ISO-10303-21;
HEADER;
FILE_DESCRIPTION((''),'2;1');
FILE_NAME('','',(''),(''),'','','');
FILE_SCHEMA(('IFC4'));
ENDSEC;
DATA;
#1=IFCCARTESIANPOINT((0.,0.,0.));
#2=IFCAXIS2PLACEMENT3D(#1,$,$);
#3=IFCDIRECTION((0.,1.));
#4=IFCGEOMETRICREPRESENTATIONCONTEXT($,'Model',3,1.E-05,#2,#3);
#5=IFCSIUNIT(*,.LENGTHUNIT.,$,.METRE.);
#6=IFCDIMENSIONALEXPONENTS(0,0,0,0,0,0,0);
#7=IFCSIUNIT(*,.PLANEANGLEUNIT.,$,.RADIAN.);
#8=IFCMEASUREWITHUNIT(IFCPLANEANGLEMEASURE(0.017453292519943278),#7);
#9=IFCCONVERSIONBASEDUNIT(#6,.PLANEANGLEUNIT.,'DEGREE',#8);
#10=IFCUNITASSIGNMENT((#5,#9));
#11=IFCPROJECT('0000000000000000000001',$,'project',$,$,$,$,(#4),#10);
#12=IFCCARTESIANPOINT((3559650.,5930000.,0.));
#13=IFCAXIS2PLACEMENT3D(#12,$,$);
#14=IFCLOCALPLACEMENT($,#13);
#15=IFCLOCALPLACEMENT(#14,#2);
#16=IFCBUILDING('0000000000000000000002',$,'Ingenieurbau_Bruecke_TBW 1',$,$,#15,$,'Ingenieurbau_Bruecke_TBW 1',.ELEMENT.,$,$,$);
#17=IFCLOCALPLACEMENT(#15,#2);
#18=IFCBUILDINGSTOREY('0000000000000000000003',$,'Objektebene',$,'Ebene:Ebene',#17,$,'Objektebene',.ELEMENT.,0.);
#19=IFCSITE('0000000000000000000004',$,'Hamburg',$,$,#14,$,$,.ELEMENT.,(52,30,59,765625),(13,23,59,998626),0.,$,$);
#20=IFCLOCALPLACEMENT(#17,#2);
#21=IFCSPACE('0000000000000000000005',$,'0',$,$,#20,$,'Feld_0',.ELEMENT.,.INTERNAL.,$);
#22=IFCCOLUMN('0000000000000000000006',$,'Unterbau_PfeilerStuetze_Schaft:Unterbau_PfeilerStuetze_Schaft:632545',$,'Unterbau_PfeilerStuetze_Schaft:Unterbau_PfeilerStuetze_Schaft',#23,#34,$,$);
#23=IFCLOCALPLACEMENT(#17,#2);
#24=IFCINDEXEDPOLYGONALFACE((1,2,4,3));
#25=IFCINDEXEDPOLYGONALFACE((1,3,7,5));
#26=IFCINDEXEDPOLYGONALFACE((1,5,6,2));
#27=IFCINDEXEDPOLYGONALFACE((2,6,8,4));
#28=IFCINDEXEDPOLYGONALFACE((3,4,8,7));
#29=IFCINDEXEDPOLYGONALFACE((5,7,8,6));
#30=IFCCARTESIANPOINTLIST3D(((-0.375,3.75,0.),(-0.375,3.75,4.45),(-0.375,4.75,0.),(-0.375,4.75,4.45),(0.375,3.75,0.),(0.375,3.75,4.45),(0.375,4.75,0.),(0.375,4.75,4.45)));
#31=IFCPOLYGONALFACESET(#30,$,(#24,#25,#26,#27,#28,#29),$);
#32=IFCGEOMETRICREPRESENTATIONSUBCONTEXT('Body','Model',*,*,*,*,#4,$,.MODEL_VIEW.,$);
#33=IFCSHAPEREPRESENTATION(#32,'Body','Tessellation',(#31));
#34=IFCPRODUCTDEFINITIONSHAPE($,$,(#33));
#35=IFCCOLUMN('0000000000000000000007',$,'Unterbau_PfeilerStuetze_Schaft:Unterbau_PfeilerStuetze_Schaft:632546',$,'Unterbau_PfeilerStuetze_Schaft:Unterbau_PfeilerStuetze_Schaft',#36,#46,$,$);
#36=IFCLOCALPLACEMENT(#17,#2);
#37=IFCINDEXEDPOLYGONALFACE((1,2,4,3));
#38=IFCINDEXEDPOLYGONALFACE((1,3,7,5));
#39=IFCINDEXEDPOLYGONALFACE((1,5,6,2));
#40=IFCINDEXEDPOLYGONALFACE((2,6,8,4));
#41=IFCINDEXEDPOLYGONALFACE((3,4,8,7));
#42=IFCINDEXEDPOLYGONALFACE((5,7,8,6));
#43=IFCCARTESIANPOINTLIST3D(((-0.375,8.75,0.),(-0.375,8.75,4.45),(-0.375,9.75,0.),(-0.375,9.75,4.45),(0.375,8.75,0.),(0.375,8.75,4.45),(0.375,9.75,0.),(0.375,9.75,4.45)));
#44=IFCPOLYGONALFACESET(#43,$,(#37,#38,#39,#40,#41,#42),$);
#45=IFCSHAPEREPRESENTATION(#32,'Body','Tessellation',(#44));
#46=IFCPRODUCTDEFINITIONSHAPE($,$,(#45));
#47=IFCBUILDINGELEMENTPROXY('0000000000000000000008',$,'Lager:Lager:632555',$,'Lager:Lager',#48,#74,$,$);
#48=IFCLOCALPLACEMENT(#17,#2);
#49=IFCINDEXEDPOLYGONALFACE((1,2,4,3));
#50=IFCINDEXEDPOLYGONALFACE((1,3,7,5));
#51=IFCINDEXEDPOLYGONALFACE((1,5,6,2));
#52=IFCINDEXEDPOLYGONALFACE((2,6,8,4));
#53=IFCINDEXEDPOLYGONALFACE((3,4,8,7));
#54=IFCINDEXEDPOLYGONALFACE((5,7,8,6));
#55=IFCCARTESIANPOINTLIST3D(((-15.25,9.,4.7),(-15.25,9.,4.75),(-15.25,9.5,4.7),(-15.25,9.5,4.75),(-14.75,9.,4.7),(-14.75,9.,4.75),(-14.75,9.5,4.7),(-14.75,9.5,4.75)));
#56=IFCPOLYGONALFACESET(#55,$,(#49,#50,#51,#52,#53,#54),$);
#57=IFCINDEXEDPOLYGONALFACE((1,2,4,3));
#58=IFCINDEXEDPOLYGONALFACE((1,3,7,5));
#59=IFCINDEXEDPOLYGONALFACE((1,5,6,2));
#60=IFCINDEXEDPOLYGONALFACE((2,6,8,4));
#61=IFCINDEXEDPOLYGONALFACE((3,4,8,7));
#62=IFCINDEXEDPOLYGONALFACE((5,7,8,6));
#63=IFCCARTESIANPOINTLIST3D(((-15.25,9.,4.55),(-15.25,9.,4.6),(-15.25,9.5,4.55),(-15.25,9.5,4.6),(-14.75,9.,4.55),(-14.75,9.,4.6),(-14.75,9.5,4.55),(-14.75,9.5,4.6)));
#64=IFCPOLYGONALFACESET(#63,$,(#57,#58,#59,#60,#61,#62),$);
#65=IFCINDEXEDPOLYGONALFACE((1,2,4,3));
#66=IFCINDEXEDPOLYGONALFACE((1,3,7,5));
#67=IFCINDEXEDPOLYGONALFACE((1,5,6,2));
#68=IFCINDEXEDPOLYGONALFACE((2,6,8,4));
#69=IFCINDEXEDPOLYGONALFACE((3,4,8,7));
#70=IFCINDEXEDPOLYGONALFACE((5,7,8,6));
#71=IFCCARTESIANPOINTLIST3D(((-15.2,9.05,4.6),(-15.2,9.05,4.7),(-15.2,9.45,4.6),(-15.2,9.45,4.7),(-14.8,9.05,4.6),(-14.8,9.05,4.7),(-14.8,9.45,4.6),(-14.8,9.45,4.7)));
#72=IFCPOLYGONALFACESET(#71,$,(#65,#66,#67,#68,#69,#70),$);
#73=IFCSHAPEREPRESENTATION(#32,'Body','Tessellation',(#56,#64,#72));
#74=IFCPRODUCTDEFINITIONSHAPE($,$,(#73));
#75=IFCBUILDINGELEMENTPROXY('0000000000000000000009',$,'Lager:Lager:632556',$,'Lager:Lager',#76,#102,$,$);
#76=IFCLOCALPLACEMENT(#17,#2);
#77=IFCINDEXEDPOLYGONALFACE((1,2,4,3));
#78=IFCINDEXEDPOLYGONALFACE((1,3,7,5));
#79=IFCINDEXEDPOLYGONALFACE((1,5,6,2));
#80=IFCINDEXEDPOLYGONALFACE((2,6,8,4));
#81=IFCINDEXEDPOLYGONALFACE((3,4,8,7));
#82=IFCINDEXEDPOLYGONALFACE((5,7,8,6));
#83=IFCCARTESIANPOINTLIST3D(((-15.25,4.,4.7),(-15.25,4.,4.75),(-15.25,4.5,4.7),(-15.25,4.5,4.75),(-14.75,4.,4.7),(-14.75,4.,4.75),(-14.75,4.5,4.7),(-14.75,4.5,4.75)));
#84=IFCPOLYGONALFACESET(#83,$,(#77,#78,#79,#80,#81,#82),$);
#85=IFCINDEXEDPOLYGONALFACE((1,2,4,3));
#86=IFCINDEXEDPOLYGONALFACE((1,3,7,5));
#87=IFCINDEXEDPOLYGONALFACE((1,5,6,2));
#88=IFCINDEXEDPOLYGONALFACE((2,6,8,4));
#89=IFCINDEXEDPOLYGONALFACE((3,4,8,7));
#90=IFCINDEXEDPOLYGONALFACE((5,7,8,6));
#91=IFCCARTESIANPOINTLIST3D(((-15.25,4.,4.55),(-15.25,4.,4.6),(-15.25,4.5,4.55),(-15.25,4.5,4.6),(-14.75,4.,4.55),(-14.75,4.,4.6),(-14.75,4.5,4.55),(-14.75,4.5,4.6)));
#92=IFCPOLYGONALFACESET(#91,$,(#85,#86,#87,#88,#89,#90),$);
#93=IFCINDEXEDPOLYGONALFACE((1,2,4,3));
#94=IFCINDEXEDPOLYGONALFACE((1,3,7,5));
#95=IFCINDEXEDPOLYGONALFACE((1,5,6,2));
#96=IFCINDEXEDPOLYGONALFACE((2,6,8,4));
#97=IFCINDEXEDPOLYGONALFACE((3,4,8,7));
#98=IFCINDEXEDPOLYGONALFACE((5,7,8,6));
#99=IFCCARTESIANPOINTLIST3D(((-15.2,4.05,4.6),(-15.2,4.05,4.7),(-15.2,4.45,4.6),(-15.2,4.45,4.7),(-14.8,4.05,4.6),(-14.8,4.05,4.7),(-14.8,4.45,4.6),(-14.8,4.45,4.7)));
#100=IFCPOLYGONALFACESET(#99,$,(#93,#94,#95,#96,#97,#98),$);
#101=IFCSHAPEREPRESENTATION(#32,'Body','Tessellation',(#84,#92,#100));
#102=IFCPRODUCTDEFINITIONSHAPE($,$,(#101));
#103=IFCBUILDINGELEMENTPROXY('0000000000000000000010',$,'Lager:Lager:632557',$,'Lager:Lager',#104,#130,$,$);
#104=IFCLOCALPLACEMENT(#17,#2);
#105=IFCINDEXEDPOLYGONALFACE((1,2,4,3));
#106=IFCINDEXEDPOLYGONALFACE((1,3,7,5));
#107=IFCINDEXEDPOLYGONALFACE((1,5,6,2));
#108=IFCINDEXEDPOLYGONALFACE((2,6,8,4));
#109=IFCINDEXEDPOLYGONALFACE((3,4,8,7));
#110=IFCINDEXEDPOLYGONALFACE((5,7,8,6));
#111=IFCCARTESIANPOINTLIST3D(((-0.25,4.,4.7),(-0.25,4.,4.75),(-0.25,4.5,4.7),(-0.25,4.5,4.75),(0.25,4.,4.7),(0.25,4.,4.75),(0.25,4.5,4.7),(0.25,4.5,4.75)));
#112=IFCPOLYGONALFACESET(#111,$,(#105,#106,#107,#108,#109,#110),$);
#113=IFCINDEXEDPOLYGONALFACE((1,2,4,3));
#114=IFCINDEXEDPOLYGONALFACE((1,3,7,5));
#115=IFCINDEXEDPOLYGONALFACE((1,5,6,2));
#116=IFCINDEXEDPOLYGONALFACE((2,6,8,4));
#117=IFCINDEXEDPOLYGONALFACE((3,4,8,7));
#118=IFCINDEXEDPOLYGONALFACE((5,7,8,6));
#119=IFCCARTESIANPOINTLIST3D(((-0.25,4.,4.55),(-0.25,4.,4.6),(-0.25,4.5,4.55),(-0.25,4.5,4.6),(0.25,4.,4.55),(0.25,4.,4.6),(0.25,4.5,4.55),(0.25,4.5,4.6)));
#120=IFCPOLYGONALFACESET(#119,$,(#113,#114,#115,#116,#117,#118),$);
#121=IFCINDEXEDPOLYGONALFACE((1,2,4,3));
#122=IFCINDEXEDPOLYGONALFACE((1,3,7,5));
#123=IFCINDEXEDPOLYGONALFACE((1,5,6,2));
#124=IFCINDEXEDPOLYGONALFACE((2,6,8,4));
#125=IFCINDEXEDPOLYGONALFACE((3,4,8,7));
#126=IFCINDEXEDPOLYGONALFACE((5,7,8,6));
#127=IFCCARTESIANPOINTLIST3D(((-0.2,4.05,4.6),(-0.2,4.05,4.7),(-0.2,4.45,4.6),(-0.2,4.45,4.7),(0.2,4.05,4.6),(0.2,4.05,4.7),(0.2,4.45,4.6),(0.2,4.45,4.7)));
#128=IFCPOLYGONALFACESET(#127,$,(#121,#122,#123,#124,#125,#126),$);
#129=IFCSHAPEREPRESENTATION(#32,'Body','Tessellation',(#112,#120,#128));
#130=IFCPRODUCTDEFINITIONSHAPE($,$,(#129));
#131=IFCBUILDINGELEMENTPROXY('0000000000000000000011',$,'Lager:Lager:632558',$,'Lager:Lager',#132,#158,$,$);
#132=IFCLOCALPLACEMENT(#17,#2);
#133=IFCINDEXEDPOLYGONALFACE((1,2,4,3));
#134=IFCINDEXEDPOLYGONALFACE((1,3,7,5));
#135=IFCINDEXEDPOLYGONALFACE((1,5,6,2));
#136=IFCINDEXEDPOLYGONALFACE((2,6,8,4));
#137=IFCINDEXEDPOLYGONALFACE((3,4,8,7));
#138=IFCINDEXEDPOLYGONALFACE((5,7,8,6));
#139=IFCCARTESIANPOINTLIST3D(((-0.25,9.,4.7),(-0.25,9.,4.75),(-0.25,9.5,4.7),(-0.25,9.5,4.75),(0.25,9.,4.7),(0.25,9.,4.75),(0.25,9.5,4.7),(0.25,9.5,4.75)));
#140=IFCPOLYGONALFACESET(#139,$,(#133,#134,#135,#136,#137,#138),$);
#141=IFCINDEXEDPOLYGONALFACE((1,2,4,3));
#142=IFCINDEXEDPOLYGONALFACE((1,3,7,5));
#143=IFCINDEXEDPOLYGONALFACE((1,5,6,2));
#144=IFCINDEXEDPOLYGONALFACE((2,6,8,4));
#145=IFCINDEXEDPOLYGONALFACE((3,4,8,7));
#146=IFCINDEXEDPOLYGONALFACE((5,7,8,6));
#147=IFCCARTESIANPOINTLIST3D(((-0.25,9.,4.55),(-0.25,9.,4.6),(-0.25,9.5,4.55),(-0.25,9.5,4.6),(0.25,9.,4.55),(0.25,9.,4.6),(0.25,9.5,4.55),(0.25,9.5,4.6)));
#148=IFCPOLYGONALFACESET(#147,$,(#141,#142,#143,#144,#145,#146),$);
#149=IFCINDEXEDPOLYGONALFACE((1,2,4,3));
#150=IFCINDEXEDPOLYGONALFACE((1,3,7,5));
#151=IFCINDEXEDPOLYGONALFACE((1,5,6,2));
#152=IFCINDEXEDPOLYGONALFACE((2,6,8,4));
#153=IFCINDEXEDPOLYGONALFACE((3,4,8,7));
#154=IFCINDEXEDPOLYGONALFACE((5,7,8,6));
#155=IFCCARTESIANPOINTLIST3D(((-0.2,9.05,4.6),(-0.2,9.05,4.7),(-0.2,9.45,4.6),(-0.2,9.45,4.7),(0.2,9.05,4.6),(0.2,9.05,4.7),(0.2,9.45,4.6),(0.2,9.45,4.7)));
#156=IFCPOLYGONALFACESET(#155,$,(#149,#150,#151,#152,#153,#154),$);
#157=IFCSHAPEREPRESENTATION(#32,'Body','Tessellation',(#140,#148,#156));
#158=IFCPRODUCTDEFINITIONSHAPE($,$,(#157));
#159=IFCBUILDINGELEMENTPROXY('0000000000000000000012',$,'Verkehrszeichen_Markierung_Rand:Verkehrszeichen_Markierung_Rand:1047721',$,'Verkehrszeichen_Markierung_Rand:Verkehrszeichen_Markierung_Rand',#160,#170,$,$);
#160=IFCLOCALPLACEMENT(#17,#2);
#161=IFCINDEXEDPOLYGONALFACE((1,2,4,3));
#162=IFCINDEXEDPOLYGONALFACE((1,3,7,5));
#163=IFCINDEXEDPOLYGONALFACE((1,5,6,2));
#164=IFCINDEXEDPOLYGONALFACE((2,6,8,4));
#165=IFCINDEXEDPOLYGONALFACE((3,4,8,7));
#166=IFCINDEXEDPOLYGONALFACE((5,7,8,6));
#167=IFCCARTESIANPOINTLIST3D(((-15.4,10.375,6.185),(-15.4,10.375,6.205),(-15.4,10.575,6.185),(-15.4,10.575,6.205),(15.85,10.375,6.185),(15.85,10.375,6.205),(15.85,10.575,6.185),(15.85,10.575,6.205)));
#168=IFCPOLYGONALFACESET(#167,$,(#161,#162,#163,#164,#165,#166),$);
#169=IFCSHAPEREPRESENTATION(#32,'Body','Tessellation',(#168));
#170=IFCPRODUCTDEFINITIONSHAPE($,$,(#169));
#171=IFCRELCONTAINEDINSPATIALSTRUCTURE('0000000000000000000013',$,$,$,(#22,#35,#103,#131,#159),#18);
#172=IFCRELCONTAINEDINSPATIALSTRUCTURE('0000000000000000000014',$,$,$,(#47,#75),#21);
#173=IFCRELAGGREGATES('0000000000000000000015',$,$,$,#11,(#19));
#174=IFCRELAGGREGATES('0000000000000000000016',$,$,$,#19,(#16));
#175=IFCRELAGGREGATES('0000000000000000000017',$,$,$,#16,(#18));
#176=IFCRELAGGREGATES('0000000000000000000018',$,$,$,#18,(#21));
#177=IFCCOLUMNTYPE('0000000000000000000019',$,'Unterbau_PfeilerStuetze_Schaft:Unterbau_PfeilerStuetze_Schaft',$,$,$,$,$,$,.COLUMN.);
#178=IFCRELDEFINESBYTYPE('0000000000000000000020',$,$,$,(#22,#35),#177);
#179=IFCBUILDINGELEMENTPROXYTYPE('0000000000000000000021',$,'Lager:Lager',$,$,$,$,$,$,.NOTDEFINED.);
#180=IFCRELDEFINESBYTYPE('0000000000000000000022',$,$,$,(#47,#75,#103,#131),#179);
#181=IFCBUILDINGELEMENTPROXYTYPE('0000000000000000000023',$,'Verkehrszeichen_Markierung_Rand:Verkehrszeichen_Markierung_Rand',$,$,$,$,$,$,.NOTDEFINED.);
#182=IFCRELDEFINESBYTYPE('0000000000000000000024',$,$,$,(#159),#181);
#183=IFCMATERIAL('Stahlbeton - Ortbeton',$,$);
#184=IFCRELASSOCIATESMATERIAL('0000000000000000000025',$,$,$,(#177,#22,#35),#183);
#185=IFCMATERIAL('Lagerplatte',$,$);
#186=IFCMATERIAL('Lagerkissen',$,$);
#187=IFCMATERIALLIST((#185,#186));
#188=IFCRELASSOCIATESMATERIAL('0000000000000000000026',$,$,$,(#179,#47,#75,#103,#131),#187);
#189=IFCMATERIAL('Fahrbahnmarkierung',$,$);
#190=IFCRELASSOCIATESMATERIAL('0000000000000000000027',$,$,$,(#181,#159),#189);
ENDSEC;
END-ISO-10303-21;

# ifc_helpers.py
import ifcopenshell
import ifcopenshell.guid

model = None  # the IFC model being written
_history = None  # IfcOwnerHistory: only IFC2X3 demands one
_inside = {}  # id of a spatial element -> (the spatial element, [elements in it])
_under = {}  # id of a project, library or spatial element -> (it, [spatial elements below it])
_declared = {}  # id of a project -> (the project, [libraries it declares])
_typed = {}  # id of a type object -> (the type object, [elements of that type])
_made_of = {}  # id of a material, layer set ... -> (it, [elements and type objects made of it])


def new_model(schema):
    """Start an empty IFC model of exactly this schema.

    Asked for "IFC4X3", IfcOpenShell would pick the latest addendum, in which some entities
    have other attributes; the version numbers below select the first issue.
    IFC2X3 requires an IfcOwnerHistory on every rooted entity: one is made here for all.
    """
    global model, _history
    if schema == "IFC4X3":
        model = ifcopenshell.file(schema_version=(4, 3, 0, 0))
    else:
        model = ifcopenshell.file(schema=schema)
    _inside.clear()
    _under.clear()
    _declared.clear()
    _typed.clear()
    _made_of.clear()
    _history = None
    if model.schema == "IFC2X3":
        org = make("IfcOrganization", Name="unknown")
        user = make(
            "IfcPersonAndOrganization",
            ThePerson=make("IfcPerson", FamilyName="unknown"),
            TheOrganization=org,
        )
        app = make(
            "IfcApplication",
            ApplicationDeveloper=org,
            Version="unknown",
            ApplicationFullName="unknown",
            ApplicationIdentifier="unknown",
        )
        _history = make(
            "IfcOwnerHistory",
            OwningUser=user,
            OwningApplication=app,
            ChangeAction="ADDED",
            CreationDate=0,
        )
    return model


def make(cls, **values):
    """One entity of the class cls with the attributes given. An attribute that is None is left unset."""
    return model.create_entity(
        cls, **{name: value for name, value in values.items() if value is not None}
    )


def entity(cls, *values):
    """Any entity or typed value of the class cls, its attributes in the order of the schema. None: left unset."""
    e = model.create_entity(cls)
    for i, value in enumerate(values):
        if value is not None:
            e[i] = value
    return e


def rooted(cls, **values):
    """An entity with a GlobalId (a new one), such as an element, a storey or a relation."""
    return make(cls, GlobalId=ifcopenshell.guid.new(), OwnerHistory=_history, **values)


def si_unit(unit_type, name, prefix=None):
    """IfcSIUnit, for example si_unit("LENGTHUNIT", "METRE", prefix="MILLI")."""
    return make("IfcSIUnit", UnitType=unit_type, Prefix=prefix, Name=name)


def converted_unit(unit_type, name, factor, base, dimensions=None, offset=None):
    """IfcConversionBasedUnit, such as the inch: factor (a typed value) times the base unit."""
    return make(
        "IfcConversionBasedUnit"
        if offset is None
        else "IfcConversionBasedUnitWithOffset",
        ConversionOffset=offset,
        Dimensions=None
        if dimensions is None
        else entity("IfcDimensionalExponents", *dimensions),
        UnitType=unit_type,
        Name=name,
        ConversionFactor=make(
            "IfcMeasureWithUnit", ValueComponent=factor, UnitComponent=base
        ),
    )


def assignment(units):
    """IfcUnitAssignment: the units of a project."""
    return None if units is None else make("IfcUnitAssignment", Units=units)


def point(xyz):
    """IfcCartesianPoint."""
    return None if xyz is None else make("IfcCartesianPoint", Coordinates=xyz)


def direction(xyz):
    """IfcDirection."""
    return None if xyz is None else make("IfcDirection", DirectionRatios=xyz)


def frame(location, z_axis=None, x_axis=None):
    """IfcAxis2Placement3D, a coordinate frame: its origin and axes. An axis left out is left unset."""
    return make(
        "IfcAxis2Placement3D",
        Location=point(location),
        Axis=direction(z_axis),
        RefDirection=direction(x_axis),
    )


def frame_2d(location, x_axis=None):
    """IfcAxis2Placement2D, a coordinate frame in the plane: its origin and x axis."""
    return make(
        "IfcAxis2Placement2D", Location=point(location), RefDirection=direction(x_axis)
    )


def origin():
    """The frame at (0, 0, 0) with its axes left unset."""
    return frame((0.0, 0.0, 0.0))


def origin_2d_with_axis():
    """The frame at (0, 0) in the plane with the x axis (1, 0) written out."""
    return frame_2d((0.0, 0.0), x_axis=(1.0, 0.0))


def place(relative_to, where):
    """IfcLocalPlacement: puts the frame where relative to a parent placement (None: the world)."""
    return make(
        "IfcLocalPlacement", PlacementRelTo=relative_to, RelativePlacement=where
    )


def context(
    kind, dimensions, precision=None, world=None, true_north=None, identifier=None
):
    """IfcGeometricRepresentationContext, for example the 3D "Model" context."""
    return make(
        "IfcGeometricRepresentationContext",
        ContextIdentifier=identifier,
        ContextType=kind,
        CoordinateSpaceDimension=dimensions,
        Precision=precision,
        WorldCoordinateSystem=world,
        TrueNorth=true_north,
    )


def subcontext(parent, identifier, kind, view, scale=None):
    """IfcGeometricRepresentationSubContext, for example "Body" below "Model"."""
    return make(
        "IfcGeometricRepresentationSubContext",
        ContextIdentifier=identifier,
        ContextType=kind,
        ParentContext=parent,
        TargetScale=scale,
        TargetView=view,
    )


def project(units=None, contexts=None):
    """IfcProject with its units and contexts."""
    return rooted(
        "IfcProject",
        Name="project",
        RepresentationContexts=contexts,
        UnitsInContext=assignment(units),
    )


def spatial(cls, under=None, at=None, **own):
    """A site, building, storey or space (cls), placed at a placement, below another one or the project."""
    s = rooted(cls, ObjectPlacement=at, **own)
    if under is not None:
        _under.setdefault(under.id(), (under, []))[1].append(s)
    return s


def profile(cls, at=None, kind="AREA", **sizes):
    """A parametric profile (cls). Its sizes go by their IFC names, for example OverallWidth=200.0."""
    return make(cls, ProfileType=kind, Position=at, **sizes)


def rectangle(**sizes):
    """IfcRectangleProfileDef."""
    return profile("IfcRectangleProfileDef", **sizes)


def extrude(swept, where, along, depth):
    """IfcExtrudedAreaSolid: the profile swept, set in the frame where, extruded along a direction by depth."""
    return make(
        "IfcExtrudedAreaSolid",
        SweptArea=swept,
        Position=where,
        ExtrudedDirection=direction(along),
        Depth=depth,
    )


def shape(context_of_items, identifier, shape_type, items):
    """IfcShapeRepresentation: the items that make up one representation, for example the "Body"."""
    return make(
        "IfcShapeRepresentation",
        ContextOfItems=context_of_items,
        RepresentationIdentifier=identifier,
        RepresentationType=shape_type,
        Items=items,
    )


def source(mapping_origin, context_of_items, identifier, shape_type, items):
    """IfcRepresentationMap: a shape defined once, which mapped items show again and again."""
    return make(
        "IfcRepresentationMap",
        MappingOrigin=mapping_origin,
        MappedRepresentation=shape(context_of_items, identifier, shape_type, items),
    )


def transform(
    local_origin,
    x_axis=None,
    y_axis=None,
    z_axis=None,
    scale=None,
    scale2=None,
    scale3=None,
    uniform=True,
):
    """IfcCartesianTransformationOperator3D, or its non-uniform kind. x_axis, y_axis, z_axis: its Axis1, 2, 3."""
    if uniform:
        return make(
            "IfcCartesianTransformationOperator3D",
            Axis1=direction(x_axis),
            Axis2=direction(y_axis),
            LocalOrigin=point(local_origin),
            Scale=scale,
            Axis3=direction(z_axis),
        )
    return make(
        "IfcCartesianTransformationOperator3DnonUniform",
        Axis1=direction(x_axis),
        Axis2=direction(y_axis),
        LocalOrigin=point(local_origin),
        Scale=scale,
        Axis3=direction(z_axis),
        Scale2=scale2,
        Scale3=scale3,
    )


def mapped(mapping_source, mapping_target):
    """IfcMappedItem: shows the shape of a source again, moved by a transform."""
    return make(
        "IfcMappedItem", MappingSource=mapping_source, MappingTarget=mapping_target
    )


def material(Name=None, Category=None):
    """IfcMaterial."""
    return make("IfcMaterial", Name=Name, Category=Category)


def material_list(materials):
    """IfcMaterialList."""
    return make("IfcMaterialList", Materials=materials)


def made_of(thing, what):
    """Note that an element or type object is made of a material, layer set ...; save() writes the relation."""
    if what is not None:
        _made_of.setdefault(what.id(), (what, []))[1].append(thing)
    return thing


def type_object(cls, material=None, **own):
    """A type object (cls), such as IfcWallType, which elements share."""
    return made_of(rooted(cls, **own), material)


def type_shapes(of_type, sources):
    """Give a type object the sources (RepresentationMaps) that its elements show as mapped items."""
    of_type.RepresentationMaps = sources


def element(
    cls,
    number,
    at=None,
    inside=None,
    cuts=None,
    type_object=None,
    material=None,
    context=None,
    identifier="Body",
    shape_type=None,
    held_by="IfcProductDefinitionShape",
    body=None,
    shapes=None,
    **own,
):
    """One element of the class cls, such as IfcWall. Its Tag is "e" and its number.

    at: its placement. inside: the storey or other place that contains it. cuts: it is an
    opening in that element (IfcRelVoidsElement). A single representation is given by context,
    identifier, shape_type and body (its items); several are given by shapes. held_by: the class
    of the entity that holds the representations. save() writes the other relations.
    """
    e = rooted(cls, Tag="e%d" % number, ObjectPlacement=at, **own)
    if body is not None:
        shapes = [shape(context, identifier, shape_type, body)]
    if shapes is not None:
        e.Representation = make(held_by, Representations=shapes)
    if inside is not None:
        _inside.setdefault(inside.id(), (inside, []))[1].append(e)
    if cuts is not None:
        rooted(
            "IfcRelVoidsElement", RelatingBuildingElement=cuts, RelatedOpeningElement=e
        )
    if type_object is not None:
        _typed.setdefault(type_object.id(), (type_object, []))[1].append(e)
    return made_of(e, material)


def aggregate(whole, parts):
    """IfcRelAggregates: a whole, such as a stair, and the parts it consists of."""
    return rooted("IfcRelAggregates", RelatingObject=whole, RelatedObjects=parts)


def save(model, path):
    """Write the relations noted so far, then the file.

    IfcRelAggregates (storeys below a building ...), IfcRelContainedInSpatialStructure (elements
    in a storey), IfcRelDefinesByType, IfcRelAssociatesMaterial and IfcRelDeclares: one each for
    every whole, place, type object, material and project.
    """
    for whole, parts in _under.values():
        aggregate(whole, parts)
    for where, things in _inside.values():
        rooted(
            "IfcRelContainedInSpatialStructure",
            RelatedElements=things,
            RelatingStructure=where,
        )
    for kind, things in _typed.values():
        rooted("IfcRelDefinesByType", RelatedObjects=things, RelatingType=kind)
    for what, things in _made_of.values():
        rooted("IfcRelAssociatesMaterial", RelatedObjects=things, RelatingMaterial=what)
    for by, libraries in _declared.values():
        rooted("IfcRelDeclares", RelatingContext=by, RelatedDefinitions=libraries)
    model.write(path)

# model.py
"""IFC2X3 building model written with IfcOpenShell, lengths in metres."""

from ifc_helpers import new_model, entity, si_unit, converted_unit, direction, frame, origin, origin_2d_with_axis, place, context, subcontext, project, spatial, rectangle, extrude, source, transform, mapped, material, material_list, type_object, type_shapes, element, save


model = new_model("IFC2X3")

# Units and contexts
model_context = context("Model", 3, precision=1e-05, world=origin(), true_north=direction((0.0, 1.0)))
body_context = subcontext(model_context, "Body", "Model", "MODEL_VIEW")
ifc_project = project(units=[si_unit("LENGTHUNIT", "METRE"), converted_unit("PLANEANGLEUNIT", "DEGREE", entity("IfcPlaneAngleMeasure", 0.017453292519943278), si_unit("PLANEANGLEUNIT", "RADIAN"), dimensions=[0, 0, 0, 0, 0, 0, 0])], contexts=[model_context])

# Site, building, storey
site_placement = place(None, frame((3559650.0, 5930000.0, 0.0)))
site = spatial("IfcSite", under=ifc_project, at=site_placement, Name="Hamburg", CompositionType="ELEMENT", RefLatitude=(52, 30, 59, 765625), RefLongitude=(13, 23, 59, 998626), RefElevation=0.0)
building_placement = place(site_placement, origin())
building = spatial("IfcBuilding", under=site, at=building_placement, Name="Ingenieurbau_Bruecke_TBW 1", LongName="Ingenieurbau_Bruecke_TBW 1", CompositionType="ELEMENT")
storey_placement = place(building_placement, origin())
storey = spatial("IfcBuildingStorey", under=building, at=storey_placement, Name="Objektebene", ObjectType="Ebene:Ebene", LongName="Objektebene", CompositionType="ELEMENT", Elevation=0.0)

# Columns
ifc_material_1 = material(Name="Stahlbeton - Ortbeton")
column_type = type_object("IfcColumnType", Name="Unterbau_PfeilerStuetze_Schaft:Unterbau_PfeilerStuetze_Schaft", PredefinedType="COLUMN", material=ifc_material_1)
shared_shape_1 = source(origin(), body_context, "Body", "SweptSolid", [
    extrude(rectangle(XDim=1.0, YDim=0.75, at=origin_2d_with_axis()), frame((0.0, 0.0, 0.0), z_axis=(0.0, 0.0, 1.0), x_axis=(0.0, 1.0, 0.0)), (0.0, 0.0, 1.0), 4.45),
])
type_shapes(column_type, [shared_shape_1])
for number, where, name in (
    (1, (0.0, 4.25, 0.0), "Unterbau_PfeilerStuetze_Schaft:Unterbau_PfeilerStuetze_Schaft:632545"),
    (2, (0.0, 9.25, 0.0), "Unterbau_PfeilerStuetze_Schaft:Unterbau_PfeilerStuetze_Schaft:632546"),
):
    element("IfcColumn", number, at=place(storey_placement, frame(where)), inside=storey, type_object=column_type, material=ifc_material_1, Name=name, ObjectType="Unterbau_PfeilerStuetze_Schaft:Unterbau_PfeilerStuetze_Schaft", context=body_context, shape_type="MappedRepresentation", body=[
        mapped(shared_shape_1, transform((0.0, 0.0, 0.0), scale=1.0)),
    ])

# Shared definitions
space_placement = place(storey_placement, origin())
space = spatial("IfcSpace", under=storey, at=space_placement, Name="0", LongName="Feld_0", CompositionType="ELEMENT", InteriorOrExteriorSpace="INTERNAL")

# Building element proxies
ifc_material_2 = material(Name="Lagerplatte")
ifc_material_3 = material(Name="Lagerkissen")
ifc_material_list_1 = material_list([ifc_material_2, ifc_material_3])
building_element_proxy_type_1 = type_object("IfcBuildingElementProxyType", Name="Lager:Lager", PredefinedType="NOTDEFINED", material=ifc_material_list_1)
shared_shape_2 = source(origin(), body_context, "Body", "SweptSolid", [
    extrude(rectangle(XDim=0.5, YDim=0.5, at=origin_2d_with_axis()), frame((0.0, 0.0, 4.7), z_axis=(0.0, 0.0, 1.0), x_axis=(0.0, 1.0, 0.0)), (0.0, 0.0, 1.0), 0.05),
    extrude(rectangle(XDim=0.5, YDim=0.5, at=origin_2d_with_axis()), frame((0.0, 0.0, 4.55), z_axis=(0.0, 0.0, 1.0), x_axis=(0.0, 1.0, 0.0)), (0.0, 0.0, 1.0), 0.05),
    extrude(rectangle(XDim=0.4, YDim=0.4, at=origin_2d_with_axis()), frame((0.0, 0.0, 4.6), z_axis=(0.0, 0.0, 1.0), x_axis=(0.0, 1.0, 0.0)), (0.0, 0.0, 1.0), 0.1),
])
type_shapes(building_element_proxy_type_1, [shared_shape_2])
for number, where, name in (
    (3, (-15.0, 9.25, 0.0), "Lager:Lager:632555"),
    (4, (-15.0, 4.25, 0.0), "Lager:Lager:632556"),
):
    element("IfcBuildingElementProxy", number, at=place(space_placement, frame(where)), inside=space, type_object=building_element_proxy_type_1, material=ifc_material_list_1, Name=name, ObjectType="Lager:Lager", context=body_context, shape_type="MappedRepresentation", body=[
        mapped(shared_shape_2, transform((0.0, 0.0, 0.0), scale=1.0)),
    ])
for number, where, name in (
    (5, (0.0, 4.25, 0.0), "Lager:Lager:632557"),
    (6, (0.0, 9.25, 0.0), "Lager:Lager:632558"),
):
    element("IfcBuildingElementProxy", number, at=place(storey_placement, frame(where)), inside=storey, type_object=building_element_proxy_type_1, material=ifc_material_list_1, Name=name, ObjectType="Lager:Lager", context=body_context, shape_type="MappedRepresentation", body=[
        mapped(shared_shape_2, transform((0.0, 0.0, 0.0), scale=1.0)),
    ])

# Building element proxy
ifc_material_4 = material(Name="Fahrbahnmarkierung")
building_element_proxy_type_2 = type_object("IfcBuildingElementProxyType", Name="Verkehrszeichen_Markierung_Rand:Verkehrszeichen_Markierung_Rand", PredefinedType="NOTDEFINED", material=ifc_material_4)
shared_shape_3 = source(origin(), body_context, "Body", "SweptSolid", [
    extrude(rectangle(XDim=31.25, YDim=0.2, at=origin_2d_with_axis()), frame((15.625, -5.335, 6.185), z_axis=(0.0, 0.0, 1.0), x_axis=(-1.0, 0.0, 0.0)), (0.0, 0.0, 1.0), 0.02),
])
type_shapes(building_element_proxy_type_2, [shared_shape_3])
proxy_1_placement = place(storey_placement, frame((-15.4, 15.81, 0.0)))
element("IfcBuildingElementProxy", 7, at=proxy_1_placement, inside=storey, type_object=building_element_proxy_type_2, material=ifc_material_4, Name="Verkehrszeichen_Markierung_Rand:Verkehrszeichen_Markierung_Rand:1047721", ObjectType="Verkehrszeichen_Markierung_Rand:Verkehrszeichen_Markierung_Rand", context=body_context, shape_type="MappedRepresentation", body=[
    mapped(shared_shape_3, transform((0.0, 0.0, 0.0), scale=1.0)),
])

save(model, "model.ifc")
